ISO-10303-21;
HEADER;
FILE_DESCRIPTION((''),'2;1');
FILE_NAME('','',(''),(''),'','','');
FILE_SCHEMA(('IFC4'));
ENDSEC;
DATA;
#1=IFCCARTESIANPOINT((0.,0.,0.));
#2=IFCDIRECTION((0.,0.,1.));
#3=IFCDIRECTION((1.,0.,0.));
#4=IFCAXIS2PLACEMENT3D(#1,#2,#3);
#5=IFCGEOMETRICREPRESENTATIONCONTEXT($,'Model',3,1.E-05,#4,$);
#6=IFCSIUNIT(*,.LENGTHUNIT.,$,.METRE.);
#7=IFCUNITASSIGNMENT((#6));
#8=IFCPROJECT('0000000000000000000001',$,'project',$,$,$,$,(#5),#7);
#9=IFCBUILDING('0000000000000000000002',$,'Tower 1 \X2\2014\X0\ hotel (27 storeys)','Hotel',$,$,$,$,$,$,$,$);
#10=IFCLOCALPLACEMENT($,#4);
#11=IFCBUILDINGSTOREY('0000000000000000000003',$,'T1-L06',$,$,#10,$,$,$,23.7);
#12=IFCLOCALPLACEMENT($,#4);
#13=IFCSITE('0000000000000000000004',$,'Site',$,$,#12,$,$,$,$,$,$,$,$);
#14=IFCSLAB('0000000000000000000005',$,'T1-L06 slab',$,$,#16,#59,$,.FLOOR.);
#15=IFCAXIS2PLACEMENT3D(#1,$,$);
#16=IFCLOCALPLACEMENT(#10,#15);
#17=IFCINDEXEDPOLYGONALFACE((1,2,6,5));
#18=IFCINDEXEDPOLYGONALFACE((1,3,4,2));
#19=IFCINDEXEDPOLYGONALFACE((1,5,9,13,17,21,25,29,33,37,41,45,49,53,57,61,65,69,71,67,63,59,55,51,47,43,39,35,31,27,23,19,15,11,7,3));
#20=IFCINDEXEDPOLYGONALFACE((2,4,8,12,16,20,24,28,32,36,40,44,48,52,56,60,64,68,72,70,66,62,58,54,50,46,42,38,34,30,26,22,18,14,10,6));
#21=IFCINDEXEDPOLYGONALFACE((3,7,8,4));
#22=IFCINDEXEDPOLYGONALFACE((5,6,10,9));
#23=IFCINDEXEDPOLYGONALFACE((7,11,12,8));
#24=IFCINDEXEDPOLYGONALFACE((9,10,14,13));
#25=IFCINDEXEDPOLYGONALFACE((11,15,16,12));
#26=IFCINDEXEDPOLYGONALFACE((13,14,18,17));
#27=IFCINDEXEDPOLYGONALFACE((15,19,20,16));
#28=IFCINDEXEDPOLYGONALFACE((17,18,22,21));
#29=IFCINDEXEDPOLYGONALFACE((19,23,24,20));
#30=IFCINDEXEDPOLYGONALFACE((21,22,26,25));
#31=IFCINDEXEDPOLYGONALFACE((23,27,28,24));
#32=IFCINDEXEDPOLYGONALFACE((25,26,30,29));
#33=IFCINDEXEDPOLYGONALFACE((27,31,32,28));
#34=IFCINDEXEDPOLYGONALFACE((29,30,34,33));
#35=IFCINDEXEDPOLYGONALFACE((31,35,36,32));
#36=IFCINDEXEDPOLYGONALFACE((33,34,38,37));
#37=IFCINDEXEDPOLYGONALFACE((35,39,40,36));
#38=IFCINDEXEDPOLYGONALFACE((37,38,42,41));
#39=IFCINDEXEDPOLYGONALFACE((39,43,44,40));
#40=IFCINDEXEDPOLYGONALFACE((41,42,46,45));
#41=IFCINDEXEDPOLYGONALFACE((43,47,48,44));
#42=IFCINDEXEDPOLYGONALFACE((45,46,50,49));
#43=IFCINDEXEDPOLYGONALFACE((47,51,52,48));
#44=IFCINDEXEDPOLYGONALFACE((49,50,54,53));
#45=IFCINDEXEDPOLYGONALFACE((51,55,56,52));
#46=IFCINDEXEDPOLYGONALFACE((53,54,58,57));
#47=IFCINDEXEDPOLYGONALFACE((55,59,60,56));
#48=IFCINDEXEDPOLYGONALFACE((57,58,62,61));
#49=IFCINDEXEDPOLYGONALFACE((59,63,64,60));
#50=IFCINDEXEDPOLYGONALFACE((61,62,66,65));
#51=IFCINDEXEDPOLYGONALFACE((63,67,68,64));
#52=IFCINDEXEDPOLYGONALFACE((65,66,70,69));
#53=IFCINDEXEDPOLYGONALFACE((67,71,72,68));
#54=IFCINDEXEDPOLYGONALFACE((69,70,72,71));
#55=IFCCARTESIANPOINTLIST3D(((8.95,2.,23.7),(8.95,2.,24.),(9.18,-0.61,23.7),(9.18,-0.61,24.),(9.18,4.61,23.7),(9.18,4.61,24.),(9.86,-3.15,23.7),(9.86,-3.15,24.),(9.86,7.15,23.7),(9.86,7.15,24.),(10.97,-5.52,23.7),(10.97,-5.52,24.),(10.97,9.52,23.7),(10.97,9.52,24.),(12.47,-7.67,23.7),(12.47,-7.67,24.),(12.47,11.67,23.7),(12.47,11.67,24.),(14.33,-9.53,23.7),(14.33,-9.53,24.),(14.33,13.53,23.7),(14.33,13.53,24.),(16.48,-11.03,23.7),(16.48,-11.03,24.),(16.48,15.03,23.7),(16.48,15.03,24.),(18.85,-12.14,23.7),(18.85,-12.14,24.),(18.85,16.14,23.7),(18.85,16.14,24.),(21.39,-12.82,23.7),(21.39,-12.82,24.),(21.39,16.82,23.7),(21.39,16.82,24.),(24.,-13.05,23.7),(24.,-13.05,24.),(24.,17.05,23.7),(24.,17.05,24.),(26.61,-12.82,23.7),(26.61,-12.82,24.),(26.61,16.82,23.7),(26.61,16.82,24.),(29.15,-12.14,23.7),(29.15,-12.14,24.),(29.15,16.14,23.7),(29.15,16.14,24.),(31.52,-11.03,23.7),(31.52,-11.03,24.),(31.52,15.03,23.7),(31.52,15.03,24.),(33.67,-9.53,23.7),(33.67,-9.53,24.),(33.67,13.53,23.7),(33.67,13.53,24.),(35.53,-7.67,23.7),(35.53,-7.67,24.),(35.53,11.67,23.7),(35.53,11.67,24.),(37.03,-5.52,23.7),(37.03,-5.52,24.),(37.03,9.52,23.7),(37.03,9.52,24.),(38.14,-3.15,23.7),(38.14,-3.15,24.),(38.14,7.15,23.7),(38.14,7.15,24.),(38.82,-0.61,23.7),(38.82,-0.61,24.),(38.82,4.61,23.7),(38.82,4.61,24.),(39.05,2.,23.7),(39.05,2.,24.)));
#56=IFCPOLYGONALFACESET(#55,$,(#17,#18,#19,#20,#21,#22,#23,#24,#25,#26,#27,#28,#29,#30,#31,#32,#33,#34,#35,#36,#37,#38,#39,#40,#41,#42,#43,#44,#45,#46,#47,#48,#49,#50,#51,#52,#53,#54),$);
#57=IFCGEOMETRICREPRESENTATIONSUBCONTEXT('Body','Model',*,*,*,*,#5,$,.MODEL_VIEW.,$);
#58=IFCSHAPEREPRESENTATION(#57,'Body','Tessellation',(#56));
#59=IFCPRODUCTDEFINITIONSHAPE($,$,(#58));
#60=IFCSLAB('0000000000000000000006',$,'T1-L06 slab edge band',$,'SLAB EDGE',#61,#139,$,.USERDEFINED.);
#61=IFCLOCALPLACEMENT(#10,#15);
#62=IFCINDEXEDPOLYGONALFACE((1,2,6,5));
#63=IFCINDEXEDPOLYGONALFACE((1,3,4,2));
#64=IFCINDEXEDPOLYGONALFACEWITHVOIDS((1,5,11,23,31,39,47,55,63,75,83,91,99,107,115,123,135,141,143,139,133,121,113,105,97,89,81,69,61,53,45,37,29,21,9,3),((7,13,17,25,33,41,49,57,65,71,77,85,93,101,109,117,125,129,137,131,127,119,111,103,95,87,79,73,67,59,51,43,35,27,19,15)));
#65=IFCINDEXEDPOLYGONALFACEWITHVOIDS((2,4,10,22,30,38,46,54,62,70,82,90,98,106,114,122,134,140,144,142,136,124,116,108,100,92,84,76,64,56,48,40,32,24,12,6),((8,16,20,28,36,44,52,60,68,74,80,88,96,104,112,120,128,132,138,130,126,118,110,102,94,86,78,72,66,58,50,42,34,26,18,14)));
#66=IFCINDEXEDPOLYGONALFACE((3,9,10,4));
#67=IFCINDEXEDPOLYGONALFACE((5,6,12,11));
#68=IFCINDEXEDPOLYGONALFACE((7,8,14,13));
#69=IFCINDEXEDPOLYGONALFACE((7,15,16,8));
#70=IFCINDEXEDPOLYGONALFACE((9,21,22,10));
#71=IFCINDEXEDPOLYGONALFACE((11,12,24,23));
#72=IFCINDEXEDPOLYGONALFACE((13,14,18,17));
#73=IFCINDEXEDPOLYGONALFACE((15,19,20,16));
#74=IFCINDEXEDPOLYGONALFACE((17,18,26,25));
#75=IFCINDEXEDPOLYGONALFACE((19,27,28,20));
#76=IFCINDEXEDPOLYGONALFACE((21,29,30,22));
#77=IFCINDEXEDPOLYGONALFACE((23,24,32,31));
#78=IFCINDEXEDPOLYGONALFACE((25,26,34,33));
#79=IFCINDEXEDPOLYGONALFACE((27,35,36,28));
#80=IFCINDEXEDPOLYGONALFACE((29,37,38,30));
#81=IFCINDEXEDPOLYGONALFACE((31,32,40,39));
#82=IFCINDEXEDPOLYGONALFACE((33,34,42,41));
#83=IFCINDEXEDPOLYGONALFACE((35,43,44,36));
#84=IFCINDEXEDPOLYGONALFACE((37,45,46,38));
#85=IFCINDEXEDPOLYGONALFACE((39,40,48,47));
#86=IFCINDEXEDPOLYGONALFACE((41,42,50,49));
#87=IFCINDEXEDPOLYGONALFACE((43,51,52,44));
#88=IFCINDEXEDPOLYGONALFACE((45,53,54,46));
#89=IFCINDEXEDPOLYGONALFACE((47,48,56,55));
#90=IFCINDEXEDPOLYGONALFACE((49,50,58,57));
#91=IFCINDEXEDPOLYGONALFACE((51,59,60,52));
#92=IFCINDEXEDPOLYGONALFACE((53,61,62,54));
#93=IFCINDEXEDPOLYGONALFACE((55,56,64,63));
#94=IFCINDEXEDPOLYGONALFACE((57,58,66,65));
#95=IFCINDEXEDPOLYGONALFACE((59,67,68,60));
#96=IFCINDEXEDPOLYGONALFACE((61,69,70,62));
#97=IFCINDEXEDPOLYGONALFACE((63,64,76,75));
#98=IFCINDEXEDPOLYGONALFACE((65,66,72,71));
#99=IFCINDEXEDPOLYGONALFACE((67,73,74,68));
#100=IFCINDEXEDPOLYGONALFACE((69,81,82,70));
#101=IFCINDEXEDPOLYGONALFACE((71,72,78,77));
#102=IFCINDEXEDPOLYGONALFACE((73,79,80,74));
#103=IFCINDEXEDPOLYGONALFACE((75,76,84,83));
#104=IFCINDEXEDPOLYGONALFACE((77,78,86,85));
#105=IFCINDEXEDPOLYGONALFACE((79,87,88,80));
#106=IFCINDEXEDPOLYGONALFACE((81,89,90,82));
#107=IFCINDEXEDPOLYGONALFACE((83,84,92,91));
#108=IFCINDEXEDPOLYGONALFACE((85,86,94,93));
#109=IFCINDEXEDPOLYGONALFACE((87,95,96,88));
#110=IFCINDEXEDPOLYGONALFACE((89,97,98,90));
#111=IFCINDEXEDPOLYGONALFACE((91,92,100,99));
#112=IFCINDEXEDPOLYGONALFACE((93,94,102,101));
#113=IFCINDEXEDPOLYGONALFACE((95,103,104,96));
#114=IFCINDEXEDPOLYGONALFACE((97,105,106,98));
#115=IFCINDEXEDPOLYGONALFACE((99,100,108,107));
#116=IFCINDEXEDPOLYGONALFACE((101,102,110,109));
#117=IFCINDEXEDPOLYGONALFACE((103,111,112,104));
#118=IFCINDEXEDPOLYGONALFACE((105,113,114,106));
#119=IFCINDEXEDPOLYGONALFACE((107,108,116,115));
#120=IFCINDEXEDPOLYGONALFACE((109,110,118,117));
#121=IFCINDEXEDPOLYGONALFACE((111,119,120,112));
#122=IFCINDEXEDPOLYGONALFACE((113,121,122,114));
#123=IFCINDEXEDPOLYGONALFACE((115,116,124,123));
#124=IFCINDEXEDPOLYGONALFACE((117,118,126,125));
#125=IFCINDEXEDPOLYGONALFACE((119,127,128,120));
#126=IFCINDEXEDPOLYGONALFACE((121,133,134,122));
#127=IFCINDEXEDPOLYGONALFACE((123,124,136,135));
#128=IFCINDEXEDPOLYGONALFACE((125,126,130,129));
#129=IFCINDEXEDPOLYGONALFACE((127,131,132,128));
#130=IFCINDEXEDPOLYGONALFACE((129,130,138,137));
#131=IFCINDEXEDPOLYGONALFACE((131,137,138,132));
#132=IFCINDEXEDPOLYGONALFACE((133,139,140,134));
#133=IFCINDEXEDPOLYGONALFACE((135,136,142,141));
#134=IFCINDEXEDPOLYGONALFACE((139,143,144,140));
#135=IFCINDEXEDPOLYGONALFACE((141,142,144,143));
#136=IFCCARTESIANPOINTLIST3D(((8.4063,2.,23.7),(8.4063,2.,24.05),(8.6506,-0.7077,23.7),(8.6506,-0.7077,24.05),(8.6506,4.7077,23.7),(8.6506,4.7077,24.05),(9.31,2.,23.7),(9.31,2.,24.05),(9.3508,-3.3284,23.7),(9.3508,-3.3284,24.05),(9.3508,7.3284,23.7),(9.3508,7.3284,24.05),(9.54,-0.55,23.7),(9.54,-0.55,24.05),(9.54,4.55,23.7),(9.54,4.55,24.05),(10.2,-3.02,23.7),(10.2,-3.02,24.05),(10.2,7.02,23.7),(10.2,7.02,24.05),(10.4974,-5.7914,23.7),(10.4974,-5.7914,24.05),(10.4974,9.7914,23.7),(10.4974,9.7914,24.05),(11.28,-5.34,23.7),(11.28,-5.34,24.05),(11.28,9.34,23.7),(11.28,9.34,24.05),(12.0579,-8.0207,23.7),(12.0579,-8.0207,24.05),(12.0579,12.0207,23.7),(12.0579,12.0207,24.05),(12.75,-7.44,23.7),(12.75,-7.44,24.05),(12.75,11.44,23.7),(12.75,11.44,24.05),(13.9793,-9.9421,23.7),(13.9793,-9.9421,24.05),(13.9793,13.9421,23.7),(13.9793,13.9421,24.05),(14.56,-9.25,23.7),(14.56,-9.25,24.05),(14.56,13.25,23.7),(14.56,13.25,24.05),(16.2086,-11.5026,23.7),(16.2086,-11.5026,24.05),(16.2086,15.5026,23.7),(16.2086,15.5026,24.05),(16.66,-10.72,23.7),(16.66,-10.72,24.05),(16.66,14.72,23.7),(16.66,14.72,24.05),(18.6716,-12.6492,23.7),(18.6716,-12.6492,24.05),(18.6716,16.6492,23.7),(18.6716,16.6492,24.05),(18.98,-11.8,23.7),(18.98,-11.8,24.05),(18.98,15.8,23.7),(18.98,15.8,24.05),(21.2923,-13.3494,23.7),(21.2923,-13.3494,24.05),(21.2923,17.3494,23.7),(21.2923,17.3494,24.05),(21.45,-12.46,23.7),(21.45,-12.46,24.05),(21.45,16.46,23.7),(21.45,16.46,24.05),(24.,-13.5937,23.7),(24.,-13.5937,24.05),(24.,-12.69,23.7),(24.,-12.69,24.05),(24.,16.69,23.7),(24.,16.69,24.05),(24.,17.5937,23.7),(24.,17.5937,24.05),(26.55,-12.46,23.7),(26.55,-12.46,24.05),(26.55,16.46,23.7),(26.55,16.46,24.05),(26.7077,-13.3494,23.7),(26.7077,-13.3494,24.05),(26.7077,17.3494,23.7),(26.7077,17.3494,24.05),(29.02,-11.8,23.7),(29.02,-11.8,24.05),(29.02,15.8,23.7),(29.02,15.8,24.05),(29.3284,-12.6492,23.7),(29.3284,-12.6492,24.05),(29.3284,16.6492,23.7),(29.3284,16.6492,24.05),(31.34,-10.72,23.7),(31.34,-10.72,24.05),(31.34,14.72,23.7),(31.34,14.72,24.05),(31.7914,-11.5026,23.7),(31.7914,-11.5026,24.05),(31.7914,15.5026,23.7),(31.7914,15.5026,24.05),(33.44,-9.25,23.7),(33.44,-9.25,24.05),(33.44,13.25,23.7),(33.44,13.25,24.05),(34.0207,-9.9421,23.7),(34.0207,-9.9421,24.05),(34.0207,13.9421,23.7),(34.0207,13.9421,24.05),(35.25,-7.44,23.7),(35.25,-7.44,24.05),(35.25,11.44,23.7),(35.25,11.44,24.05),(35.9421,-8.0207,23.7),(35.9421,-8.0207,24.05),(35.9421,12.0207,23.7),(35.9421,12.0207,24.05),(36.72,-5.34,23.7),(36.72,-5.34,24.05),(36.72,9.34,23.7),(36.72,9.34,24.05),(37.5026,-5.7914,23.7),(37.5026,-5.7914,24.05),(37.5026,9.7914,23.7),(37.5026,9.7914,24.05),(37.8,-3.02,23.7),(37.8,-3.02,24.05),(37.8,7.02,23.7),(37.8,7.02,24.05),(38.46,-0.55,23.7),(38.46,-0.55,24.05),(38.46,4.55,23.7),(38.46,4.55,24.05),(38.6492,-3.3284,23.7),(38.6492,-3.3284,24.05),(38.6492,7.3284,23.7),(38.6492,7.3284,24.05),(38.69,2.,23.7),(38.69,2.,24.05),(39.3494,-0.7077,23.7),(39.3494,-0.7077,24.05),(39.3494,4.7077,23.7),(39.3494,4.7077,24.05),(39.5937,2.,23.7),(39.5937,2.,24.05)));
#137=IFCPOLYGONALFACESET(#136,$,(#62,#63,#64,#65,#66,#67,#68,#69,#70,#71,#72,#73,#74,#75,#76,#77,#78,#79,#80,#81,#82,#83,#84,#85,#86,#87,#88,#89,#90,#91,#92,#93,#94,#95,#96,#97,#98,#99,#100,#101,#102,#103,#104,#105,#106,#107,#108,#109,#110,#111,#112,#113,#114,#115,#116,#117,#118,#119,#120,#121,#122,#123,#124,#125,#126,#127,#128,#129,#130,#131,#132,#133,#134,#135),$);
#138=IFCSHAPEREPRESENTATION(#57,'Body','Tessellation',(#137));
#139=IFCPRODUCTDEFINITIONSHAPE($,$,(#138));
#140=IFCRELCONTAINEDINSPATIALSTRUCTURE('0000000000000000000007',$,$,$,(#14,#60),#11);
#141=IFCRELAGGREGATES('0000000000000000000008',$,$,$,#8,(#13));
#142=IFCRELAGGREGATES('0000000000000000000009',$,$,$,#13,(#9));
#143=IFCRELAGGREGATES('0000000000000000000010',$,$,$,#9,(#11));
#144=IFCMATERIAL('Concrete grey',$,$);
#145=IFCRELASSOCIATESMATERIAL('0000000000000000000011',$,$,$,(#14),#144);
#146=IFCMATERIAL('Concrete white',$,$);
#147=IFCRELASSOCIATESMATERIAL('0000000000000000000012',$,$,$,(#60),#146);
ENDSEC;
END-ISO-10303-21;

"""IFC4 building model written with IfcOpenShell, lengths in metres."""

from ifc_helpers import new_model, si_unit, frame, origin_with_axes, place, context, subcontext, project, spatial, polyline, outline, extrude, material, element, save


model = new_model("IFC4")

# Units and contexts
model_context = context("Model", 3, precision=1e-05, world=origin_with_axes())
body_context = subcontext(model_context, "Body", "Model", "MODEL_VIEW")
ifc_project = project(units=[si_unit("LENGTHUNIT", "METRE")], contexts=[model_context])

# Site, building, storey
site_placement = place(None, origin_with_axes())
site = spatial("IfcSite", under=ifc_project, at=site_placement, Name="Site")
building = spatial("IfcBuilding", under=site, Name="Tower 1 — hotel (27 storeys)", Description="Hotel")
storey_placement = place(None, origin_with_axes())
storey = spatial("IfcBuildingStorey", under=building, at=storey_placement, Name="T1-L06", Elevation=23.7)

# Slab
ifc_material_1 = material(Name="Concrete grey")
slab_1_placement = place(storey_placement, origin_with_axes())
element("IfcSlab", 1, at=slab_1_placement, inside=storey, material=ifc_material_1, Name="T1-L06 slab", PredefinedType="FLOOR", context=body_context, shape_type="SweptSolid", body=[
    extrude(outline(polyline([(38.82, -0.61), (39.05, 2.0), (38.82, 4.61), (38.14, 7.15), (37.03, 9.52), (35.53, 11.67), (33.67, 13.53), (31.52, 15.03), (29.15, 16.14), (26.61, 16.82), (24.0, 17.05), (21.39, 16.82), (18.85, 16.14), (16.48, 15.03), (14.33, 13.53), (12.47, 11.67), (10.97, 9.52), (9.86, 7.15), (9.18, 4.61), (8.95, 2.0), (9.18, -0.61), (9.86, -3.15), (10.97, -5.52), (12.47, -7.67), (14.33, -9.53), (16.48, -11.03), (18.85, -12.14), (21.39, -12.82), (24.0, -13.05), (26.61, -12.82), (29.15, -12.14), (31.52, -11.03), (33.67, -9.53), (35.53, -7.67), (37.03, -5.52), (38.14, -3.15), (38.82, -0.61)])), frame((0.0, 0.0, 23.7), z_axis=(0.0, 0.0, 1.0), x_axis=(1.0, 0.0, 0.0)), (0.0, 0.0, 1.0), 0.3),
])

# Slab
ifc_material_2 = material(Name="Concrete white")
slab_2_placement = place(storey_placement, origin_with_axes())
element("IfcSlab", 2, at=slab_2_placement, inside=storey, material=ifc_material_2, Name="T1-L06 slab edge band", ObjectType="SLAB EDGE", PredefinedType="USERDEFINED", context=body_context, shape_type="SweptSolid", body=[
    extrude(outline(polyline([(39.5937, 2.0), (39.3494, 4.7077), (38.6492, 7.3284), (37.5026, 9.7914), (35.9421, 12.0207), (34.0207, 13.9421), (31.7914, 15.5026), (29.3284, 16.6492), (26.7077, 17.3494), (24.0, 17.5937), (21.2923, 17.3494), (18.6716, 16.6492), (16.2086, 15.5026), (13.9793, 13.9421), (12.0579, 12.0207), (10.4974, 9.7914), (9.3508, 7.3284), (8.6506, 4.7077), (8.4063, 2.0), (8.6506, -0.7077), (9.3508, -3.3284), (10.4974, -5.7914), (12.0579, -8.0207), (13.9793, -9.9421), (16.2086, -11.5026), (18.6716, -12.6492), (21.2923, -13.3494), (24.0, -13.5937), (26.7077, -13.3494), (29.3284, -12.6492), (31.7914, -11.5026), (34.0207, -9.9421), (35.9421, -8.0207), (37.5026, -5.7914), (38.6492, -3.3284), (39.3494, -0.7077), (39.5937, 2.0)]), holes=[polyline([(38.69, 2.0), (38.46, 4.55), (37.8, 7.02), (36.72, 9.34), (35.25, 11.44), (33.44, 13.25), (31.34, 14.72), (29.02, 15.8), (26.55, 16.46), (24.0, 16.69), (21.45, 16.46), (18.98, 15.8), (16.66, 14.72), (14.56, 13.25), (12.75, 11.44), (11.28, 9.34), (10.2, 7.02), (9.54, 4.55), (9.31, 2.0), (9.54, -0.55), (10.2, -3.02), (11.28, -5.34), (12.75, -7.44), (14.56, -9.25), (16.66, -10.72), (18.98, -11.8), (21.45, -12.46), (24.0, -12.69), (26.55, -12.46), (29.02, -11.8), (31.34, -10.72), (33.44, -9.25), (35.25, -7.44), (36.72, -5.34), (37.8, -3.02), (38.46, -0.55), (38.69, 2.0)])]), frame((0.0, 0.0, 23.7), z_axis=(0.0, 0.0, 1.0), x_axis=(1.0, 0.0, 0.0)), (0.0, 0.0, 1.0), 0.35),
])

save(model, "model.ifc")
